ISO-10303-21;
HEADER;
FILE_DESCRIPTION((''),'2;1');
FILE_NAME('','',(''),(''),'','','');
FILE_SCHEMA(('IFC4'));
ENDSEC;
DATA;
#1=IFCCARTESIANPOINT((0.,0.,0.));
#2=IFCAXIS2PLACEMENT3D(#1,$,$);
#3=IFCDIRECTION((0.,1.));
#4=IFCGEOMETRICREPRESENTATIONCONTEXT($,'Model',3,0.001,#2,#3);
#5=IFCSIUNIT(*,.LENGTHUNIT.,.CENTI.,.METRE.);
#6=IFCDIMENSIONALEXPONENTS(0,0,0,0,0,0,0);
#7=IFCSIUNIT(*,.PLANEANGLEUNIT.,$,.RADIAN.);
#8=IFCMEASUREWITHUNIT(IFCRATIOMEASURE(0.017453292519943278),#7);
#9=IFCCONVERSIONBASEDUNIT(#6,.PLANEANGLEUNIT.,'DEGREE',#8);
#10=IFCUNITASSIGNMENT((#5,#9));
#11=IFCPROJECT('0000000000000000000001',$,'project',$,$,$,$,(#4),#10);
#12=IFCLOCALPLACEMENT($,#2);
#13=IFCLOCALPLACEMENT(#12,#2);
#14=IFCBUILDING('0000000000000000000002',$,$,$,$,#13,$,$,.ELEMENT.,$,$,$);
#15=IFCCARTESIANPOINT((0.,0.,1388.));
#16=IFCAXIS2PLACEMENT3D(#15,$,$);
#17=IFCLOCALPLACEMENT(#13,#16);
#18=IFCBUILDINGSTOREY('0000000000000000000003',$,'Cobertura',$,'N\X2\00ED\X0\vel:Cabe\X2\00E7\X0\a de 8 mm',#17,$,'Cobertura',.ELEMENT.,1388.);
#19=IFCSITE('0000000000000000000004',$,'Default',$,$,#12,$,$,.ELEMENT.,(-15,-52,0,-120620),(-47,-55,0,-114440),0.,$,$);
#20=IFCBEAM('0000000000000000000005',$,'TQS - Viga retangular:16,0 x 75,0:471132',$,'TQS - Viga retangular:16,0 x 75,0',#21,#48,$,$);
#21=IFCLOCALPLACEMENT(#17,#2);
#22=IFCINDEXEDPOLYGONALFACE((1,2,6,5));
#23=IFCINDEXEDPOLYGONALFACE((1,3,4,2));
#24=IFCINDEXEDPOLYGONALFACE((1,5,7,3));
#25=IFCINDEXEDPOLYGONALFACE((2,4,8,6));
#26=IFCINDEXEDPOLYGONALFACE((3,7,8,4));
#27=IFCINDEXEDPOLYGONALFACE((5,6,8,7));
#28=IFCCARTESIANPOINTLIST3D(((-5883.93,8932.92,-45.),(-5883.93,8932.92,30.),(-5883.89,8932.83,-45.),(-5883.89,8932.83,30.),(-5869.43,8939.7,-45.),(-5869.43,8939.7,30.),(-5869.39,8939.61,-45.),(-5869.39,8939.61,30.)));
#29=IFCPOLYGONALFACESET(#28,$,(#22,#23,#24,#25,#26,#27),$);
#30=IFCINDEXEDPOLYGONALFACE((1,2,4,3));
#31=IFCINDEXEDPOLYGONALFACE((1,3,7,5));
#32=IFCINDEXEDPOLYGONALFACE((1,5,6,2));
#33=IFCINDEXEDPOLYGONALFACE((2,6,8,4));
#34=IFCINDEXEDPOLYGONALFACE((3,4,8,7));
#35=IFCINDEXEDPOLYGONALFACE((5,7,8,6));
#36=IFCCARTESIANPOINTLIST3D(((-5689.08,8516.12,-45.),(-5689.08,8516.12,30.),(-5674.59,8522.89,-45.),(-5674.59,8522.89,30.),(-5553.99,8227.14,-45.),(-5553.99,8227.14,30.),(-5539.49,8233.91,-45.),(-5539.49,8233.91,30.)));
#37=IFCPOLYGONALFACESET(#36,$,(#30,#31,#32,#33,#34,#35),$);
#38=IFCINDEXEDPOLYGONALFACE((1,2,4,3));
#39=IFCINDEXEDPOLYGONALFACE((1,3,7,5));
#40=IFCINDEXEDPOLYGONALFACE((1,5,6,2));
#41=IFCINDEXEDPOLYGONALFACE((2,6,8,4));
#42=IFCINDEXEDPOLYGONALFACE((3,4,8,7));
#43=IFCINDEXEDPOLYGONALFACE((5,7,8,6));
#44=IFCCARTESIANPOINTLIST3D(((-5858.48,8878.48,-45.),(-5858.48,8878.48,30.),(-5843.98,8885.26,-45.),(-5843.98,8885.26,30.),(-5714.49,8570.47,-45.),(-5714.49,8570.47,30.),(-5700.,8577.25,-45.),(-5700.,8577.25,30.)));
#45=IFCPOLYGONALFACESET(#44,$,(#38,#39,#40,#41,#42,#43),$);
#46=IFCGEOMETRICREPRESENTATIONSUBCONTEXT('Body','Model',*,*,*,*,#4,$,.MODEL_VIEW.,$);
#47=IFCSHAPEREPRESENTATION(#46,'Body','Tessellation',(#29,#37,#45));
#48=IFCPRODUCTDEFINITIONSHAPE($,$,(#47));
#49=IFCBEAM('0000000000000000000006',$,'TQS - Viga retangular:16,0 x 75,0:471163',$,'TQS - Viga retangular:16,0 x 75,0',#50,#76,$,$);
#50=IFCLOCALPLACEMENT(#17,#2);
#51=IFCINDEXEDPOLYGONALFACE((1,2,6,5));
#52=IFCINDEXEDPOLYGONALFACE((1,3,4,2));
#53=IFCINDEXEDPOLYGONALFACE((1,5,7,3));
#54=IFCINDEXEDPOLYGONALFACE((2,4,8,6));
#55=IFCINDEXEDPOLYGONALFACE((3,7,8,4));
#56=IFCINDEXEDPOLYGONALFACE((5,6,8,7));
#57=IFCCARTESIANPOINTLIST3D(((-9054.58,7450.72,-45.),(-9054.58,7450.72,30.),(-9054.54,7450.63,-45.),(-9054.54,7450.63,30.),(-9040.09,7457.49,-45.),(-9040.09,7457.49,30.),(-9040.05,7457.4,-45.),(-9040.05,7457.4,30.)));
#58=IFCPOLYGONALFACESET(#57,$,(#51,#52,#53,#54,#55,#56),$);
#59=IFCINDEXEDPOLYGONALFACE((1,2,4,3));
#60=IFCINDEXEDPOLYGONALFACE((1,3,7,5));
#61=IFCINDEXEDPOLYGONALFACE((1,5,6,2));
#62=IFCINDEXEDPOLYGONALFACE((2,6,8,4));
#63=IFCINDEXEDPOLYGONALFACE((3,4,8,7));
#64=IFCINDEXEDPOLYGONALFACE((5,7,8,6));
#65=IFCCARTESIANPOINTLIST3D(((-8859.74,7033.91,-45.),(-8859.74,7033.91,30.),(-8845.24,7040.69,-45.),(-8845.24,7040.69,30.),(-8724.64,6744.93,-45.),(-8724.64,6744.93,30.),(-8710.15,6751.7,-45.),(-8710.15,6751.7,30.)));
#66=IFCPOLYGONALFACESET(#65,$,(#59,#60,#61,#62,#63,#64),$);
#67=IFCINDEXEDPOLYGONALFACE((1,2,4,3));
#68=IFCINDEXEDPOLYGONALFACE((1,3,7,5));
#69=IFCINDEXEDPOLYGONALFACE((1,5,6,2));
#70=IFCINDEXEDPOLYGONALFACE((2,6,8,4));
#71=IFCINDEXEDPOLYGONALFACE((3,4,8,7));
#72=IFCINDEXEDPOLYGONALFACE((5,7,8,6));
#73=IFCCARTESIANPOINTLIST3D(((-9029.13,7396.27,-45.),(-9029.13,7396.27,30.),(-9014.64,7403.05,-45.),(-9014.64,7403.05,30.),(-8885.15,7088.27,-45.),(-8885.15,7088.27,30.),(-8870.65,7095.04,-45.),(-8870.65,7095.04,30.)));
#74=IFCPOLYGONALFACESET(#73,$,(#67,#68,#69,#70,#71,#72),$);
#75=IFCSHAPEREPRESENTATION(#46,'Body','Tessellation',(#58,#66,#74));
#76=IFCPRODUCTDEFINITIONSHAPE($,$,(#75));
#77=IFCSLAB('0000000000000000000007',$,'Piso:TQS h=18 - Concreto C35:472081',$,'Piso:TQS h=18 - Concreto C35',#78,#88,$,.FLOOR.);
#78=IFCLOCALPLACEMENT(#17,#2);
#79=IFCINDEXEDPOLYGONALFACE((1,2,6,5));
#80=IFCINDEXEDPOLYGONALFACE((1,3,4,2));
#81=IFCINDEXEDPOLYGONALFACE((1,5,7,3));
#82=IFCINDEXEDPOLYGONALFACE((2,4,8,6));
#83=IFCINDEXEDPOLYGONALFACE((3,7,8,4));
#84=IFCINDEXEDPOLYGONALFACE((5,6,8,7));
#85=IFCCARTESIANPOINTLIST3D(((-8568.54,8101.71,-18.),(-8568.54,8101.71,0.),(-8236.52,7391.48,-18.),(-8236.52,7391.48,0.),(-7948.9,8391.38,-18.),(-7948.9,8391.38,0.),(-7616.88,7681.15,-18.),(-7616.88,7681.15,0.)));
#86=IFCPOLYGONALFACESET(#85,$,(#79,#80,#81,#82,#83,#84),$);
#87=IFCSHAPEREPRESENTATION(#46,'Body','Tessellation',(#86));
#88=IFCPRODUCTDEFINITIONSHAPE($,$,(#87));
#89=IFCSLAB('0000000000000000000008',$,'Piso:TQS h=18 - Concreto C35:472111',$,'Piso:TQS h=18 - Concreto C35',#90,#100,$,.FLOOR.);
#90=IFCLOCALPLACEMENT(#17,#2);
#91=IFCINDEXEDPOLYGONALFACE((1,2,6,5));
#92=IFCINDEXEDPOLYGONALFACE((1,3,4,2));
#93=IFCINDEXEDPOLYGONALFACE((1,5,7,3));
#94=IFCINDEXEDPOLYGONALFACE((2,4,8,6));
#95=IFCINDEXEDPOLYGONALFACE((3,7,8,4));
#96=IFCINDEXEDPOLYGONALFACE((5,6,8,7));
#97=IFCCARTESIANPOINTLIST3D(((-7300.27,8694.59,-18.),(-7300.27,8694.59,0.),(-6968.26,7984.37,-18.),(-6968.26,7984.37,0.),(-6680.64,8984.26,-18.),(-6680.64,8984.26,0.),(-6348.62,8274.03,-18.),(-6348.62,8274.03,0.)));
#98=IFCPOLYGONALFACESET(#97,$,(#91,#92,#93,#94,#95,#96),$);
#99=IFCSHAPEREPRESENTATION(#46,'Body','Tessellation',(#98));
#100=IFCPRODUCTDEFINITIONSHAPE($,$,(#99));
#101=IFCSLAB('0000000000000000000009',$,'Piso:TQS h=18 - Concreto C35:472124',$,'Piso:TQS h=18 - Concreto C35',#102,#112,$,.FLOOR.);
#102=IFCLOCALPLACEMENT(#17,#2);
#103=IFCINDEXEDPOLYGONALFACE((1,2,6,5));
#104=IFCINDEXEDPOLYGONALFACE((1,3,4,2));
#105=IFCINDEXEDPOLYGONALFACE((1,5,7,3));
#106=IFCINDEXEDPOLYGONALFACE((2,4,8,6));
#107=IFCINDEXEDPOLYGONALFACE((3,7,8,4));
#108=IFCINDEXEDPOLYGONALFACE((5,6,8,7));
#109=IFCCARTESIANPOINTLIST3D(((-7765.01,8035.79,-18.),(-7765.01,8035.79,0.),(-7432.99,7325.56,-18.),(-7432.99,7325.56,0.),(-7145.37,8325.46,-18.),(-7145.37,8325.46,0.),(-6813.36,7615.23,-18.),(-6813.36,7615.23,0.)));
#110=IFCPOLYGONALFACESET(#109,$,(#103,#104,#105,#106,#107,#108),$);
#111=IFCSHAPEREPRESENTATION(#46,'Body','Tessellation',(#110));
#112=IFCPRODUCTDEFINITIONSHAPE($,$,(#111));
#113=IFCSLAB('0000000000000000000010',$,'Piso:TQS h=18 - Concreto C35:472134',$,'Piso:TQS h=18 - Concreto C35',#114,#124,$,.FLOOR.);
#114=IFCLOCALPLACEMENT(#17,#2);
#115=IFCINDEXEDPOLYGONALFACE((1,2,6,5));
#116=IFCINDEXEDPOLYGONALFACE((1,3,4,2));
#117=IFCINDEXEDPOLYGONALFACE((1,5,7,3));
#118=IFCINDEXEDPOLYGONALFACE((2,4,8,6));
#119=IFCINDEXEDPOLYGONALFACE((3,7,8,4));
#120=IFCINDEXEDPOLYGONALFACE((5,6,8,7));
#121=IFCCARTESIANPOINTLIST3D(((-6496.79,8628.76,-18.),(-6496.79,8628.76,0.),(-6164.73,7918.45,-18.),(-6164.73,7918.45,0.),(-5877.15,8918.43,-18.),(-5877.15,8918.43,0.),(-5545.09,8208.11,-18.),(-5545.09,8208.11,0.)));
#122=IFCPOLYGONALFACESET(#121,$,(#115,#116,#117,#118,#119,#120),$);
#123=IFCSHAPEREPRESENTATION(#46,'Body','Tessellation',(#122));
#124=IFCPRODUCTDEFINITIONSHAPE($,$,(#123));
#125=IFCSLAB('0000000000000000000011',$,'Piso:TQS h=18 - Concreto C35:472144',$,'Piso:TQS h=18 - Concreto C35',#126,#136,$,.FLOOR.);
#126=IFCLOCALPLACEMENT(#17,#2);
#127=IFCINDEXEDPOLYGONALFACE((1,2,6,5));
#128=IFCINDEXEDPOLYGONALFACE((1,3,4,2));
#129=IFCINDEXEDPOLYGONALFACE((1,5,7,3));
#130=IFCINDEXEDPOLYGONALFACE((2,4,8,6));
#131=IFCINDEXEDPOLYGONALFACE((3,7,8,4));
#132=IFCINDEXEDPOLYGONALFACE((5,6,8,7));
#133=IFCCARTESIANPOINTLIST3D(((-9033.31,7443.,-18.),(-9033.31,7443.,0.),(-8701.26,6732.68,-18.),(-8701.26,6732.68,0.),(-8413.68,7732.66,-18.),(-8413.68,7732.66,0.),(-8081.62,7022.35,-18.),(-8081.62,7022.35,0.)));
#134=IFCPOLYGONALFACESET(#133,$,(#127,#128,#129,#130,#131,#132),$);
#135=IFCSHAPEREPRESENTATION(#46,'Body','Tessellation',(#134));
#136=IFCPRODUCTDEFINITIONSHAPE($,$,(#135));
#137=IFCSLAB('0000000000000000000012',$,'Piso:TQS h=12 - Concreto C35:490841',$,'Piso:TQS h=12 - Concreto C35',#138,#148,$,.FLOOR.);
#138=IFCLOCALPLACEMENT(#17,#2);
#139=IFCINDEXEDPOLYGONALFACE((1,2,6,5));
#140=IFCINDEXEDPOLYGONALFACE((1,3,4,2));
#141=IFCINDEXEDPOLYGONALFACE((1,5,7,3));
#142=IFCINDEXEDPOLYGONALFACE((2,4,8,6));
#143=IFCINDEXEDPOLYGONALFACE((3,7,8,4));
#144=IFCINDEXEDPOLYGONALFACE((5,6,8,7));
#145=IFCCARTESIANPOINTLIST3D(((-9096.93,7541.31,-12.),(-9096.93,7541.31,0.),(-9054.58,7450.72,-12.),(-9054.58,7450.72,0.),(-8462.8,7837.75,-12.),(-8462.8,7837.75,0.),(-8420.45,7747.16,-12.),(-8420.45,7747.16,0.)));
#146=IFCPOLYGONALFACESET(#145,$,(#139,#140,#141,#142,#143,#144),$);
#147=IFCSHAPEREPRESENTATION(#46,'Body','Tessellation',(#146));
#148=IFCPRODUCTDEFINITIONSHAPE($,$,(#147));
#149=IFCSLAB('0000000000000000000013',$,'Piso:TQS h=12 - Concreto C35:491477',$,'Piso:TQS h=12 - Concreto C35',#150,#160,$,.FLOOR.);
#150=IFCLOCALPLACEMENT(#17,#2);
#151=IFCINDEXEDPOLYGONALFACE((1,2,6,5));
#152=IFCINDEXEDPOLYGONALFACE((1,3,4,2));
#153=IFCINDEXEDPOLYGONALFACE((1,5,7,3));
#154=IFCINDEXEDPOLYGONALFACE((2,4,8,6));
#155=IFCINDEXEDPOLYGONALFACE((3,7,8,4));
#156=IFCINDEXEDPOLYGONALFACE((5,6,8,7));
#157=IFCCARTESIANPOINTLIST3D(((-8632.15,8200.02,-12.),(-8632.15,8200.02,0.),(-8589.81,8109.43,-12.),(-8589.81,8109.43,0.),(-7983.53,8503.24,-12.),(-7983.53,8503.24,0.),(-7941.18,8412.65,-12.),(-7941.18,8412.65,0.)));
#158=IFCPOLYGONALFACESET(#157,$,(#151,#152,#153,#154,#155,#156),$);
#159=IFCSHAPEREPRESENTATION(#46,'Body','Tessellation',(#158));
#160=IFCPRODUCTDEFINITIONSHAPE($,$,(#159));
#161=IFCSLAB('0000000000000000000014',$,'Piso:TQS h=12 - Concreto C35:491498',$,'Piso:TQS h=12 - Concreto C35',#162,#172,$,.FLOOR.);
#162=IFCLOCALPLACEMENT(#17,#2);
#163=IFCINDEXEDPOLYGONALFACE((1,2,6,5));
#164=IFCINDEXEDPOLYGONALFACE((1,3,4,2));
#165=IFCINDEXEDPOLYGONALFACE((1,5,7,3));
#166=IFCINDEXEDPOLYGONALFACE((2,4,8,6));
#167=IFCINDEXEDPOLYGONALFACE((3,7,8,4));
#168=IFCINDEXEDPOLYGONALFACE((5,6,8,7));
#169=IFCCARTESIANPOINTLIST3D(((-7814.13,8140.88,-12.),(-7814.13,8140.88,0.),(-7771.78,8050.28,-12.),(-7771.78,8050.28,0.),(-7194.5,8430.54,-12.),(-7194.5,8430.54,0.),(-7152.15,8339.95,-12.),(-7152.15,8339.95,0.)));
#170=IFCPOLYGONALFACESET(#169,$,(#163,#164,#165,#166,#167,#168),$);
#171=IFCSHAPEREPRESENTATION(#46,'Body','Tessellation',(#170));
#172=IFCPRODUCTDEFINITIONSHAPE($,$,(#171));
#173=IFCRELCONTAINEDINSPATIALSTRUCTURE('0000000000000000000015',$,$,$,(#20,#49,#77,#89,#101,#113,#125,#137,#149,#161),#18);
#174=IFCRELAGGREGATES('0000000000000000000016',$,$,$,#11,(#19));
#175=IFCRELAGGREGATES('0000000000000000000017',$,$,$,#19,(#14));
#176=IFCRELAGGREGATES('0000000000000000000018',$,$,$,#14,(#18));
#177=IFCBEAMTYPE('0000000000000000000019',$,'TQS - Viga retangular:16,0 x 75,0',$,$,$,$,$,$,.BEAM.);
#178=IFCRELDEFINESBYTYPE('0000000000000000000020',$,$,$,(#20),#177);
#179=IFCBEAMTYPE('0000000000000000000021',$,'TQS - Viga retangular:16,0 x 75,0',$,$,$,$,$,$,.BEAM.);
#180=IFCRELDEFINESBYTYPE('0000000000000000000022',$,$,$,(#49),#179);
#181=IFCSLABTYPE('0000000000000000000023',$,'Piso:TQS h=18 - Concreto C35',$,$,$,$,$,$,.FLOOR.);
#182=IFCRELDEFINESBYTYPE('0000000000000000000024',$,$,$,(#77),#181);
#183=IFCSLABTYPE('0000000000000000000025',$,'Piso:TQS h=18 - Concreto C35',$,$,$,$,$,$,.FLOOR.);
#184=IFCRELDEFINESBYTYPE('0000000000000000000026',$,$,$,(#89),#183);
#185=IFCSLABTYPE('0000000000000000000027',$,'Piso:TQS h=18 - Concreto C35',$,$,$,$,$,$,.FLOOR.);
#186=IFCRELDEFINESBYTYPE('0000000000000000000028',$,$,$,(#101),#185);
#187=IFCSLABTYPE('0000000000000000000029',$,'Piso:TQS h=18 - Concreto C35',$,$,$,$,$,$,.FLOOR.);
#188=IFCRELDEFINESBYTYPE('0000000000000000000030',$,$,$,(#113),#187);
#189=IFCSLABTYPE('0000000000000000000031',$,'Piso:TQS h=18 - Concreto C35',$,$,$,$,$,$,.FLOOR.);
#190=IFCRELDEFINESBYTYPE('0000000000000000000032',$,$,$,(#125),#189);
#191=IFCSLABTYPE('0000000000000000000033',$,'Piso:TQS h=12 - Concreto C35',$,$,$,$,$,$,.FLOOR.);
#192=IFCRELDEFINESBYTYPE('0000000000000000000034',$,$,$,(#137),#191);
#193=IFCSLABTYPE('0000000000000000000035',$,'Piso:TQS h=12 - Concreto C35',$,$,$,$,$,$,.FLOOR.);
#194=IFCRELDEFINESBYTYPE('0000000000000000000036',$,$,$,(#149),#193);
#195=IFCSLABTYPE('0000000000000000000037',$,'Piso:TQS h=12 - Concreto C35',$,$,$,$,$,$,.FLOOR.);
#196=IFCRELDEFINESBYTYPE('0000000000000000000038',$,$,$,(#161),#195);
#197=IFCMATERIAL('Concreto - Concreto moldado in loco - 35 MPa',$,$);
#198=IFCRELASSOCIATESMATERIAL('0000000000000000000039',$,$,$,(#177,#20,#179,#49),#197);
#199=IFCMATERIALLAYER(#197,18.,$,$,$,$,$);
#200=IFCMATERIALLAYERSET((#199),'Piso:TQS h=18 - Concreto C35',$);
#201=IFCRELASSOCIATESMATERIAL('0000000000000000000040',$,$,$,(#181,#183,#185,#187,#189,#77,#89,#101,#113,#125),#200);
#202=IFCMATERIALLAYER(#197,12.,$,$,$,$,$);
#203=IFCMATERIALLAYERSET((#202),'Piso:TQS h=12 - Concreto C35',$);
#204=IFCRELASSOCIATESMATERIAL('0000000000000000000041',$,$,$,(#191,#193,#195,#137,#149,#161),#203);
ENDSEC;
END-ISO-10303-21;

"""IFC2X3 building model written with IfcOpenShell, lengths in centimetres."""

from ifc_helpers import new_model, entity, si_unit, converted_unit, direction, frame, frame_2d, origin, origin_2d_with_axis, place, context, subcontext, project, spatial, rectangle, extrude, source, transform, mapped, material, layer, layer_set, layer_usage, type_object, type_shapes, element, save


model = new_model("IFC2X3")

# Units and contexts
model_context = context("Model", 3, precision=0.001, world=origin(), true_north=direction((0.0, 1.0)))
body_context = subcontext(model_context, "Body", "Model", "MODEL_VIEW")
ifc_project = project(units=[si_unit("LENGTHUNIT", "METRE", prefix="CENTI"), converted_unit("PLANEANGLEUNIT", "DEGREE", entity("IfcRatioMeasure", 0.017453292519943278), si_unit("PLANEANGLEUNIT", "RADIAN"), dimensions=[0, 0, 0, 0, 0, 0, 0])], contexts=[model_context])

# Site, building, storey
site_placement = place(None, origin())
site = spatial("IfcSite", under=ifc_project, at=site_placement, Name="Default", CompositionType="ELEMENT", RefLatitude=(-15, -52, 0, -120620), RefLongitude=(-47, -55, 0, -114440), RefElevation=0.0)
building_placement = place(site_placement, origin())
building = spatial("IfcBuilding", under=site, at=building_placement, CompositionType="ELEMENT")
storey_placement = place(building_placement, frame((0.0, 0.0, 1388.0)))
storey = spatial("IfcBuildingStorey", under=building, at=storey_placement, Name="Cobertura", ObjectType="Nível:Cabeça de 8 mm", LongName="Cobertura", CompositionType="ELEMENT", Elevation=1388.0)

# Beams
ifc_material = material(Name="Concreto - Concreto moldado in loco - 35 MPa")
beam_type_1 = type_object("IfcBeamType", Name="TQS - Viga retangular:16,0 x 75,0", PredefinedType="BEAM", material=ifc_material)
shared_shape_1 = source(origin(), body_context, "Body", "SweptSolid", [
    extrude(rectangle(XDim=75.0, YDim=16.0, at=frame_2d((0.0, 0.0), x_axis=(1.0, 0.0))), frame((-5876.64, 8936.22, 1380.5), z_axis=(-0.423488, 0.905902, 0.0), x_axis=(0.0, 0.0, 1.0)), (0.0, 0.0, 1.0), 0.1),
    extrude(rectangle(XDim=75.0, YDim=16.0, at=frame_2d((0.0, 0.0), x_axis=(1.0, 0.0))), frame((-5546.74, 8230.52, 1380.5), z_axis=(-0.423488, 0.905902, 0.0), x_axis=(0.0, 0.0, 1.0)), (0.0, 0.0, 1.0), 319.0),
    extrude(rectangle(XDim=75.0, YDim=16.0, at=frame_2d((0.0, 0.0), x_axis=(1.0, 0.0))), frame((-5707.24, 8573.86, 1380.5), z_axis=(-0.423488, 0.905902, 0.0), x_axis=(0.0, 0.0, 1.0)), (0.0, 0.0, 1.0), 340.0),
])
type_shapes(beam_type_1, [shared_shape_1])
beam_1_placement = place(storey_placement, frame((0.0, 0.0, -1388.0)))
element("IfcBeam", 1, at=beam_1_placement, inside=storey, type_object=beam_type_1, material=ifc_material, Name="TQS - Viga retangular:16,0 x 75,0:471132", ObjectType="TQS - Viga retangular:16,0 x 75,0", context=body_context, shape_type="MappedRepresentation", body=[
    mapped(shared_shape_1, transform((0.0, 0.0, 0.0), scale=1.0)),
])
beam_type_2 = type_object("IfcBeamType", Name="TQS - Viga retangular:16,0 x 75,0", PredefinedType="BEAM", material=ifc_material)
shared_shape_2 = source(origin(), body_context, "Body", "SweptSolid", [
    extrude(rectangle(XDim=75.0, YDim=16.0, at=frame_2d((0.0, 0.0), x_axis=(1.0, 0.0))), frame((-9047.29, 7454.01, 1380.5), z_axis=(-0.423488, 0.905902, 0.0), x_axis=(0.0, 0.0, 1.0)), (0.0, 0.0, 1.0), 0.1),
    extrude(rectangle(XDim=75.0, YDim=16.0, at=frame_2d((0.0, 0.0), x_axis=(1.0, 0.0))), frame((-8717.4, 6748.32, 1380.5), z_axis=(-0.423488, 0.905902, 0.0), x_axis=(0.0, 0.0, 1.0)), (0.0, 0.0, 1.0), 319.0),
    extrude(rectangle(XDim=75.0, YDim=16.0, at=frame_2d((0.0, 0.0), x_axis=(1.0, 0.0))), frame((-8877.9, 7091.65, 1380.5), z_axis=(-0.423488, 0.905902, 0.0), x_axis=(0.0, 0.0, 1.0)), (0.0, 0.0, 1.0), 340.0),
])
type_shapes(beam_type_2, [shared_shape_2])
beam_2_placement = place(storey_placement, frame((0.0, 0.0, -1388.0)))
element("IfcBeam", 2, at=beam_2_placement, inside=storey, type_object=beam_type_2, material=ifc_material, Name="TQS - Viga retangular:16,0 x 75,0:471163", ObjectType="TQS - Viga retangular:16,0 x 75,0", context=body_context, shape_type="MappedRepresentation", body=[
    mapped(shared_shape_2, transform((0.0, 0.0, 0.0), scale=1.0)),
])

# Slabs
ifc_layer_1 = layer(ifc_material, 18.0)
ifc_layer_set_1 = layer_set([ifc_layer_1], Name="Piso:TQS h=18 - Concreto C35")
ifc_layer_usage_1 = layer_usage(ifc_layer_set_1, "AXIS3", "POSITIVE", 0.0)
slab_type_1 = type_object("IfcSlabType", Name="Piso:TQS h=18 - Concreto C35", PredefinedType="FLOOR", material=ifc_layer_set_1)
slab_1_placement = place(storey_placement, origin())
element("IfcSlab", 3, at=slab_1_placement, inside=storey, type_object=slab_type_1, material=ifc_layer_usage_1, Name="Piso:TQS h=18 - Concreto C35:472081", ObjectType="Piso:TQS h=18 - Concreto C35", PredefinedType="FLOOR", context=body_context, shape_type="SweptSolid", body=[
    extrude(rectangle(XDim=684.0, YDim=784.0, at=frame_2d((0.0, 0.0), x_axis=(1.0, 0.0))), frame((-8092.71, 7891.43, 0.0), z_axis=(0.0, 0.0, -1.0), x_axis=(-0.905902, -0.423488, 0.0)), (0.0, 0.0, 1.0), 18.0),
])
ifc_layer_usage_2 = layer_usage(ifc_layer_set_1, "AXIS3", "POSITIVE", 0.0)
slab_type_2 = type_object("IfcSlabType", Name="Piso:TQS h=18 - Concreto C35", PredefinedType="FLOOR", material=ifc_layer_set_1)
slab_2_placement = place(storey_placement, origin())
element("IfcSlab", 4, at=slab_2_placement, inside=storey, type_object=slab_type_2, material=ifc_layer_usage_2, Name="Piso:TQS h=18 - Concreto C35:472111", ObjectType="Piso:TQS h=18 - Concreto C35", PredefinedType="FLOOR", context=body_context, shape_type="SweptSolid", body=[
    extrude(rectangle(XDim=784.0, YDim=684.0, at=origin_2d_with_axis()), frame((-6824.45, 8484.31, 0.0), z_axis=(0.0, 0.0, -1.0), x_axis=(0.423488, -0.905902, 0.0)), (0.0, 0.0, 1.0), 18.0),
])
ifc_layer_usage_3 = layer_usage(ifc_layer_set_1, "AXIS3", "POSITIVE", 0.0)
slab_type_3 = type_object("IfcSlabType", Name="Piso:TQS h=18 - Concreto C35", PredefinedType="FLOOR", material=ifc_layer_set_1)
slab_3_placement = place(storey_placement, origin())
element("IfcSlab", 5, at=slab_3_placement, inside=storey, type_object=slab_type_3, material=ifc_layer_usage_3, Name="Piso:TQS h=18 - Concreto C35:472124", ObjectType="Piso:TQS h=18 - Concreto C35", PredefinedType="FLOOR", context=body_context, shape_type="SweptSolid", body=[
    extrude(rectangle(XDim=684.0, YDim=784.0, at=frame_2d((0.0, 0.0), x_axis=(1.0, 0.0))), frame((-7289.18, 7825.51, 0.0), z_axis=(0.0, 0.0, -1.0), x_axis=(-0.905902, -0.423488, 0.0)), (0.0, 0.0, 1.0), 18.0),
])
ifc_layer_usage_4 = layer_usage(ifc_layer_set_1, "AXIS3", "POSITIVE", 0.0)
slab_type_4 = type_object("IfcSlabType", Name="Piso:TQS h=18 - Concreto C35", PredefinedType="FLOOR", material=ifc_layer_set_1)
slab_4_placement = place(storey_placement, origin())
element("IfcSlab", 6, at=slab_4_placement, inside=storey, type_object=slab_type_4, material=ifc_layer_usage_4, Name="Piso:TQS h=18 - Concreto C35:472134", ObjectType="Piso:TQS h=18 - Concreto C35", PredefinedType="FLOOR", context=body_context, shape_type="SweptSolid", body=[
    extrude(rectangle(XDim=684.0, YDim=784.1, at=frame_2d((0.0, 0.0), x_axis=(1.0, 0.0))), frame((-6020.94, 8418.44, 0.0), z_axis=(0.0, 0.0, -1.0), x_axis=(0.905902, 0.423488, 0.0)), (0.0, 0.0, 1.0), 18.0),
])
ifc_layer_usage_5 = layer_usage(ifc_layer_set_1, "AXIS3", "POSITIVE", 0.0)
slab_type_5 = type_object("IfcSlabType", Name="Piso:TQS h=18 - Concreto C35", PredefinedType="FLOOR", material=ifc_layer_set_1)
slab_5_placement = place(storey_placement, origin())
element("IfcSlab", 7, at=slab_5_placement, inside=storey, type_object=slab_type_5, material=ifc_layer_usage_5, Name="Piso:TQS h=18 - Concreto C35:472144", ObjectType="Piso:TQS h=18 - Concreto C35", PredefinedType="FLOOR", context=body_context, shape_type="SweptSolid", body=[
    extrude(rectangle(XDim=684.0, YDim=784.1, at=frame_2d((0.0, 0.0), x_axis=(1.0, 0.0))), frame((-8557.47, 7232.67, 0.0), z_axis=(0.0, 0.0, -1.0), x_axis=(0.905902, 0.423488, 0.0)), (0.0, 0.0, 1.0), 18.0),
])
ifc_layer_2 = layer(ifc_material, 12.0)
ifc_layer_set_2 = layer_set([ifc_layer_2], Name="Piso:TQS h=12 - Concreto C35")
ifc_layer_usage_6 = layer_usage(ifc_layer_set_2, "AXIS3", "POSITIVE", 0.0)
slab_type_6 = type_object("IfcSlabType", Name="Piso:TQS h=12 - Concreto C35", PredefinedType="FLOOR", material=ifc_layer_set_2)
slab_6_placement = place(storey_placement, origin())
element("IfcSlab", 8, at=slab_6_placement, inside=storey, type_object=slab_type_6, material=ifc_layer_usage_6, Name="Piso:TQS h=12 - Concreto C35:490841", ObjectType="Piso:TQS h=12 - Concreto C35", PredefinedType="FLOOR", context=body_context, shape_type="SweptSolid", body=[
    extrude(rectangle(XDim=100.0, YDim=700.0, at=frame_2d((0.0, 0.0), x_axis=(1.0, 0.0))), frame((-8758.69, 7644.23, 0.0), z_axis=(0.0, 0.0, -1.0), x_axis=(0.423488, -0.905902, 0.0)), (0.0, 0.0, 1.0), 12.0),
])
ifc_layer_usage_7 = layer_usage(ifc_layer_set_2, "AXIS3", "POSITIVE", 0.0)
slab_type_7 = type_object("IfcSlabType", Name="Piso:TQS h=12 - Concreto C35", PredefinedType="FLOOR", material=ifc_layer_set_2)
slab_7_placement = place(storey_placement, origin())
element("IfcSlab", 9, at=slab_7_placement, inside=storey, type_object=slab_type_7, material=ifc_layer_usage_7, Name="Piso:TQS h=12 - Concreto C35:491477", ObjectType="Piso:TQS h=12 - Concreto C35", PredefinedType="FLOOR", context=body_context, shape_type="SweptSolid", body=[
    extrude(rectangle(XDim=100.0, YDim=716.0, at=frame_2d((0.0, 0.0), x_axis=(1.0, 0.0))), frame((-8286.67, 8306.33, 0.0), z_axis=(0.0, 0.0, -1.0), x_axis=(0.423488, -0.905902, 0.0)), (0.0, 0.0, 1.0), 12.0),
])
ifc_layer_usage_8 = layer_usage(ifc_layer_set_2, "AXIS3", "POSITIVE", 0.0)
slab_type_8 = type_object("IfcSlabType", Name="Piso:TQS h=12 - Concreto C35", PredefinedType="FLOOR", material=ifc_layer_set_2)
slab_8_placement = place(storey_placement, origin())
element("IfcSlab", 10, at=slab_8_placement, inside=storey, type_object=slab_type_8, material=ifc_layer_usage_8, Name="Piso:TQS h=12 - Concreto C35:491498", ObjectType="Piso:TQS h=12 - Concreto C35", PredefinedType="FLOOR", context=body_context, shape_type="SweptSolid", body=[
    extrude(rectangle(XDim=100.0, YDim=684.0, at=frame_2d((0.0, 0.0), x_axis=(1.0, 0.0))), frame((-7483.14, 8240.41, 0.0), z_axis=(0.0, 0.0, -1.0), x_axis=(0.423488, -0.905902, 0.0)), (0.0, 0.0, 1.0), 12.0),
])

save(model, "model.ifc")
